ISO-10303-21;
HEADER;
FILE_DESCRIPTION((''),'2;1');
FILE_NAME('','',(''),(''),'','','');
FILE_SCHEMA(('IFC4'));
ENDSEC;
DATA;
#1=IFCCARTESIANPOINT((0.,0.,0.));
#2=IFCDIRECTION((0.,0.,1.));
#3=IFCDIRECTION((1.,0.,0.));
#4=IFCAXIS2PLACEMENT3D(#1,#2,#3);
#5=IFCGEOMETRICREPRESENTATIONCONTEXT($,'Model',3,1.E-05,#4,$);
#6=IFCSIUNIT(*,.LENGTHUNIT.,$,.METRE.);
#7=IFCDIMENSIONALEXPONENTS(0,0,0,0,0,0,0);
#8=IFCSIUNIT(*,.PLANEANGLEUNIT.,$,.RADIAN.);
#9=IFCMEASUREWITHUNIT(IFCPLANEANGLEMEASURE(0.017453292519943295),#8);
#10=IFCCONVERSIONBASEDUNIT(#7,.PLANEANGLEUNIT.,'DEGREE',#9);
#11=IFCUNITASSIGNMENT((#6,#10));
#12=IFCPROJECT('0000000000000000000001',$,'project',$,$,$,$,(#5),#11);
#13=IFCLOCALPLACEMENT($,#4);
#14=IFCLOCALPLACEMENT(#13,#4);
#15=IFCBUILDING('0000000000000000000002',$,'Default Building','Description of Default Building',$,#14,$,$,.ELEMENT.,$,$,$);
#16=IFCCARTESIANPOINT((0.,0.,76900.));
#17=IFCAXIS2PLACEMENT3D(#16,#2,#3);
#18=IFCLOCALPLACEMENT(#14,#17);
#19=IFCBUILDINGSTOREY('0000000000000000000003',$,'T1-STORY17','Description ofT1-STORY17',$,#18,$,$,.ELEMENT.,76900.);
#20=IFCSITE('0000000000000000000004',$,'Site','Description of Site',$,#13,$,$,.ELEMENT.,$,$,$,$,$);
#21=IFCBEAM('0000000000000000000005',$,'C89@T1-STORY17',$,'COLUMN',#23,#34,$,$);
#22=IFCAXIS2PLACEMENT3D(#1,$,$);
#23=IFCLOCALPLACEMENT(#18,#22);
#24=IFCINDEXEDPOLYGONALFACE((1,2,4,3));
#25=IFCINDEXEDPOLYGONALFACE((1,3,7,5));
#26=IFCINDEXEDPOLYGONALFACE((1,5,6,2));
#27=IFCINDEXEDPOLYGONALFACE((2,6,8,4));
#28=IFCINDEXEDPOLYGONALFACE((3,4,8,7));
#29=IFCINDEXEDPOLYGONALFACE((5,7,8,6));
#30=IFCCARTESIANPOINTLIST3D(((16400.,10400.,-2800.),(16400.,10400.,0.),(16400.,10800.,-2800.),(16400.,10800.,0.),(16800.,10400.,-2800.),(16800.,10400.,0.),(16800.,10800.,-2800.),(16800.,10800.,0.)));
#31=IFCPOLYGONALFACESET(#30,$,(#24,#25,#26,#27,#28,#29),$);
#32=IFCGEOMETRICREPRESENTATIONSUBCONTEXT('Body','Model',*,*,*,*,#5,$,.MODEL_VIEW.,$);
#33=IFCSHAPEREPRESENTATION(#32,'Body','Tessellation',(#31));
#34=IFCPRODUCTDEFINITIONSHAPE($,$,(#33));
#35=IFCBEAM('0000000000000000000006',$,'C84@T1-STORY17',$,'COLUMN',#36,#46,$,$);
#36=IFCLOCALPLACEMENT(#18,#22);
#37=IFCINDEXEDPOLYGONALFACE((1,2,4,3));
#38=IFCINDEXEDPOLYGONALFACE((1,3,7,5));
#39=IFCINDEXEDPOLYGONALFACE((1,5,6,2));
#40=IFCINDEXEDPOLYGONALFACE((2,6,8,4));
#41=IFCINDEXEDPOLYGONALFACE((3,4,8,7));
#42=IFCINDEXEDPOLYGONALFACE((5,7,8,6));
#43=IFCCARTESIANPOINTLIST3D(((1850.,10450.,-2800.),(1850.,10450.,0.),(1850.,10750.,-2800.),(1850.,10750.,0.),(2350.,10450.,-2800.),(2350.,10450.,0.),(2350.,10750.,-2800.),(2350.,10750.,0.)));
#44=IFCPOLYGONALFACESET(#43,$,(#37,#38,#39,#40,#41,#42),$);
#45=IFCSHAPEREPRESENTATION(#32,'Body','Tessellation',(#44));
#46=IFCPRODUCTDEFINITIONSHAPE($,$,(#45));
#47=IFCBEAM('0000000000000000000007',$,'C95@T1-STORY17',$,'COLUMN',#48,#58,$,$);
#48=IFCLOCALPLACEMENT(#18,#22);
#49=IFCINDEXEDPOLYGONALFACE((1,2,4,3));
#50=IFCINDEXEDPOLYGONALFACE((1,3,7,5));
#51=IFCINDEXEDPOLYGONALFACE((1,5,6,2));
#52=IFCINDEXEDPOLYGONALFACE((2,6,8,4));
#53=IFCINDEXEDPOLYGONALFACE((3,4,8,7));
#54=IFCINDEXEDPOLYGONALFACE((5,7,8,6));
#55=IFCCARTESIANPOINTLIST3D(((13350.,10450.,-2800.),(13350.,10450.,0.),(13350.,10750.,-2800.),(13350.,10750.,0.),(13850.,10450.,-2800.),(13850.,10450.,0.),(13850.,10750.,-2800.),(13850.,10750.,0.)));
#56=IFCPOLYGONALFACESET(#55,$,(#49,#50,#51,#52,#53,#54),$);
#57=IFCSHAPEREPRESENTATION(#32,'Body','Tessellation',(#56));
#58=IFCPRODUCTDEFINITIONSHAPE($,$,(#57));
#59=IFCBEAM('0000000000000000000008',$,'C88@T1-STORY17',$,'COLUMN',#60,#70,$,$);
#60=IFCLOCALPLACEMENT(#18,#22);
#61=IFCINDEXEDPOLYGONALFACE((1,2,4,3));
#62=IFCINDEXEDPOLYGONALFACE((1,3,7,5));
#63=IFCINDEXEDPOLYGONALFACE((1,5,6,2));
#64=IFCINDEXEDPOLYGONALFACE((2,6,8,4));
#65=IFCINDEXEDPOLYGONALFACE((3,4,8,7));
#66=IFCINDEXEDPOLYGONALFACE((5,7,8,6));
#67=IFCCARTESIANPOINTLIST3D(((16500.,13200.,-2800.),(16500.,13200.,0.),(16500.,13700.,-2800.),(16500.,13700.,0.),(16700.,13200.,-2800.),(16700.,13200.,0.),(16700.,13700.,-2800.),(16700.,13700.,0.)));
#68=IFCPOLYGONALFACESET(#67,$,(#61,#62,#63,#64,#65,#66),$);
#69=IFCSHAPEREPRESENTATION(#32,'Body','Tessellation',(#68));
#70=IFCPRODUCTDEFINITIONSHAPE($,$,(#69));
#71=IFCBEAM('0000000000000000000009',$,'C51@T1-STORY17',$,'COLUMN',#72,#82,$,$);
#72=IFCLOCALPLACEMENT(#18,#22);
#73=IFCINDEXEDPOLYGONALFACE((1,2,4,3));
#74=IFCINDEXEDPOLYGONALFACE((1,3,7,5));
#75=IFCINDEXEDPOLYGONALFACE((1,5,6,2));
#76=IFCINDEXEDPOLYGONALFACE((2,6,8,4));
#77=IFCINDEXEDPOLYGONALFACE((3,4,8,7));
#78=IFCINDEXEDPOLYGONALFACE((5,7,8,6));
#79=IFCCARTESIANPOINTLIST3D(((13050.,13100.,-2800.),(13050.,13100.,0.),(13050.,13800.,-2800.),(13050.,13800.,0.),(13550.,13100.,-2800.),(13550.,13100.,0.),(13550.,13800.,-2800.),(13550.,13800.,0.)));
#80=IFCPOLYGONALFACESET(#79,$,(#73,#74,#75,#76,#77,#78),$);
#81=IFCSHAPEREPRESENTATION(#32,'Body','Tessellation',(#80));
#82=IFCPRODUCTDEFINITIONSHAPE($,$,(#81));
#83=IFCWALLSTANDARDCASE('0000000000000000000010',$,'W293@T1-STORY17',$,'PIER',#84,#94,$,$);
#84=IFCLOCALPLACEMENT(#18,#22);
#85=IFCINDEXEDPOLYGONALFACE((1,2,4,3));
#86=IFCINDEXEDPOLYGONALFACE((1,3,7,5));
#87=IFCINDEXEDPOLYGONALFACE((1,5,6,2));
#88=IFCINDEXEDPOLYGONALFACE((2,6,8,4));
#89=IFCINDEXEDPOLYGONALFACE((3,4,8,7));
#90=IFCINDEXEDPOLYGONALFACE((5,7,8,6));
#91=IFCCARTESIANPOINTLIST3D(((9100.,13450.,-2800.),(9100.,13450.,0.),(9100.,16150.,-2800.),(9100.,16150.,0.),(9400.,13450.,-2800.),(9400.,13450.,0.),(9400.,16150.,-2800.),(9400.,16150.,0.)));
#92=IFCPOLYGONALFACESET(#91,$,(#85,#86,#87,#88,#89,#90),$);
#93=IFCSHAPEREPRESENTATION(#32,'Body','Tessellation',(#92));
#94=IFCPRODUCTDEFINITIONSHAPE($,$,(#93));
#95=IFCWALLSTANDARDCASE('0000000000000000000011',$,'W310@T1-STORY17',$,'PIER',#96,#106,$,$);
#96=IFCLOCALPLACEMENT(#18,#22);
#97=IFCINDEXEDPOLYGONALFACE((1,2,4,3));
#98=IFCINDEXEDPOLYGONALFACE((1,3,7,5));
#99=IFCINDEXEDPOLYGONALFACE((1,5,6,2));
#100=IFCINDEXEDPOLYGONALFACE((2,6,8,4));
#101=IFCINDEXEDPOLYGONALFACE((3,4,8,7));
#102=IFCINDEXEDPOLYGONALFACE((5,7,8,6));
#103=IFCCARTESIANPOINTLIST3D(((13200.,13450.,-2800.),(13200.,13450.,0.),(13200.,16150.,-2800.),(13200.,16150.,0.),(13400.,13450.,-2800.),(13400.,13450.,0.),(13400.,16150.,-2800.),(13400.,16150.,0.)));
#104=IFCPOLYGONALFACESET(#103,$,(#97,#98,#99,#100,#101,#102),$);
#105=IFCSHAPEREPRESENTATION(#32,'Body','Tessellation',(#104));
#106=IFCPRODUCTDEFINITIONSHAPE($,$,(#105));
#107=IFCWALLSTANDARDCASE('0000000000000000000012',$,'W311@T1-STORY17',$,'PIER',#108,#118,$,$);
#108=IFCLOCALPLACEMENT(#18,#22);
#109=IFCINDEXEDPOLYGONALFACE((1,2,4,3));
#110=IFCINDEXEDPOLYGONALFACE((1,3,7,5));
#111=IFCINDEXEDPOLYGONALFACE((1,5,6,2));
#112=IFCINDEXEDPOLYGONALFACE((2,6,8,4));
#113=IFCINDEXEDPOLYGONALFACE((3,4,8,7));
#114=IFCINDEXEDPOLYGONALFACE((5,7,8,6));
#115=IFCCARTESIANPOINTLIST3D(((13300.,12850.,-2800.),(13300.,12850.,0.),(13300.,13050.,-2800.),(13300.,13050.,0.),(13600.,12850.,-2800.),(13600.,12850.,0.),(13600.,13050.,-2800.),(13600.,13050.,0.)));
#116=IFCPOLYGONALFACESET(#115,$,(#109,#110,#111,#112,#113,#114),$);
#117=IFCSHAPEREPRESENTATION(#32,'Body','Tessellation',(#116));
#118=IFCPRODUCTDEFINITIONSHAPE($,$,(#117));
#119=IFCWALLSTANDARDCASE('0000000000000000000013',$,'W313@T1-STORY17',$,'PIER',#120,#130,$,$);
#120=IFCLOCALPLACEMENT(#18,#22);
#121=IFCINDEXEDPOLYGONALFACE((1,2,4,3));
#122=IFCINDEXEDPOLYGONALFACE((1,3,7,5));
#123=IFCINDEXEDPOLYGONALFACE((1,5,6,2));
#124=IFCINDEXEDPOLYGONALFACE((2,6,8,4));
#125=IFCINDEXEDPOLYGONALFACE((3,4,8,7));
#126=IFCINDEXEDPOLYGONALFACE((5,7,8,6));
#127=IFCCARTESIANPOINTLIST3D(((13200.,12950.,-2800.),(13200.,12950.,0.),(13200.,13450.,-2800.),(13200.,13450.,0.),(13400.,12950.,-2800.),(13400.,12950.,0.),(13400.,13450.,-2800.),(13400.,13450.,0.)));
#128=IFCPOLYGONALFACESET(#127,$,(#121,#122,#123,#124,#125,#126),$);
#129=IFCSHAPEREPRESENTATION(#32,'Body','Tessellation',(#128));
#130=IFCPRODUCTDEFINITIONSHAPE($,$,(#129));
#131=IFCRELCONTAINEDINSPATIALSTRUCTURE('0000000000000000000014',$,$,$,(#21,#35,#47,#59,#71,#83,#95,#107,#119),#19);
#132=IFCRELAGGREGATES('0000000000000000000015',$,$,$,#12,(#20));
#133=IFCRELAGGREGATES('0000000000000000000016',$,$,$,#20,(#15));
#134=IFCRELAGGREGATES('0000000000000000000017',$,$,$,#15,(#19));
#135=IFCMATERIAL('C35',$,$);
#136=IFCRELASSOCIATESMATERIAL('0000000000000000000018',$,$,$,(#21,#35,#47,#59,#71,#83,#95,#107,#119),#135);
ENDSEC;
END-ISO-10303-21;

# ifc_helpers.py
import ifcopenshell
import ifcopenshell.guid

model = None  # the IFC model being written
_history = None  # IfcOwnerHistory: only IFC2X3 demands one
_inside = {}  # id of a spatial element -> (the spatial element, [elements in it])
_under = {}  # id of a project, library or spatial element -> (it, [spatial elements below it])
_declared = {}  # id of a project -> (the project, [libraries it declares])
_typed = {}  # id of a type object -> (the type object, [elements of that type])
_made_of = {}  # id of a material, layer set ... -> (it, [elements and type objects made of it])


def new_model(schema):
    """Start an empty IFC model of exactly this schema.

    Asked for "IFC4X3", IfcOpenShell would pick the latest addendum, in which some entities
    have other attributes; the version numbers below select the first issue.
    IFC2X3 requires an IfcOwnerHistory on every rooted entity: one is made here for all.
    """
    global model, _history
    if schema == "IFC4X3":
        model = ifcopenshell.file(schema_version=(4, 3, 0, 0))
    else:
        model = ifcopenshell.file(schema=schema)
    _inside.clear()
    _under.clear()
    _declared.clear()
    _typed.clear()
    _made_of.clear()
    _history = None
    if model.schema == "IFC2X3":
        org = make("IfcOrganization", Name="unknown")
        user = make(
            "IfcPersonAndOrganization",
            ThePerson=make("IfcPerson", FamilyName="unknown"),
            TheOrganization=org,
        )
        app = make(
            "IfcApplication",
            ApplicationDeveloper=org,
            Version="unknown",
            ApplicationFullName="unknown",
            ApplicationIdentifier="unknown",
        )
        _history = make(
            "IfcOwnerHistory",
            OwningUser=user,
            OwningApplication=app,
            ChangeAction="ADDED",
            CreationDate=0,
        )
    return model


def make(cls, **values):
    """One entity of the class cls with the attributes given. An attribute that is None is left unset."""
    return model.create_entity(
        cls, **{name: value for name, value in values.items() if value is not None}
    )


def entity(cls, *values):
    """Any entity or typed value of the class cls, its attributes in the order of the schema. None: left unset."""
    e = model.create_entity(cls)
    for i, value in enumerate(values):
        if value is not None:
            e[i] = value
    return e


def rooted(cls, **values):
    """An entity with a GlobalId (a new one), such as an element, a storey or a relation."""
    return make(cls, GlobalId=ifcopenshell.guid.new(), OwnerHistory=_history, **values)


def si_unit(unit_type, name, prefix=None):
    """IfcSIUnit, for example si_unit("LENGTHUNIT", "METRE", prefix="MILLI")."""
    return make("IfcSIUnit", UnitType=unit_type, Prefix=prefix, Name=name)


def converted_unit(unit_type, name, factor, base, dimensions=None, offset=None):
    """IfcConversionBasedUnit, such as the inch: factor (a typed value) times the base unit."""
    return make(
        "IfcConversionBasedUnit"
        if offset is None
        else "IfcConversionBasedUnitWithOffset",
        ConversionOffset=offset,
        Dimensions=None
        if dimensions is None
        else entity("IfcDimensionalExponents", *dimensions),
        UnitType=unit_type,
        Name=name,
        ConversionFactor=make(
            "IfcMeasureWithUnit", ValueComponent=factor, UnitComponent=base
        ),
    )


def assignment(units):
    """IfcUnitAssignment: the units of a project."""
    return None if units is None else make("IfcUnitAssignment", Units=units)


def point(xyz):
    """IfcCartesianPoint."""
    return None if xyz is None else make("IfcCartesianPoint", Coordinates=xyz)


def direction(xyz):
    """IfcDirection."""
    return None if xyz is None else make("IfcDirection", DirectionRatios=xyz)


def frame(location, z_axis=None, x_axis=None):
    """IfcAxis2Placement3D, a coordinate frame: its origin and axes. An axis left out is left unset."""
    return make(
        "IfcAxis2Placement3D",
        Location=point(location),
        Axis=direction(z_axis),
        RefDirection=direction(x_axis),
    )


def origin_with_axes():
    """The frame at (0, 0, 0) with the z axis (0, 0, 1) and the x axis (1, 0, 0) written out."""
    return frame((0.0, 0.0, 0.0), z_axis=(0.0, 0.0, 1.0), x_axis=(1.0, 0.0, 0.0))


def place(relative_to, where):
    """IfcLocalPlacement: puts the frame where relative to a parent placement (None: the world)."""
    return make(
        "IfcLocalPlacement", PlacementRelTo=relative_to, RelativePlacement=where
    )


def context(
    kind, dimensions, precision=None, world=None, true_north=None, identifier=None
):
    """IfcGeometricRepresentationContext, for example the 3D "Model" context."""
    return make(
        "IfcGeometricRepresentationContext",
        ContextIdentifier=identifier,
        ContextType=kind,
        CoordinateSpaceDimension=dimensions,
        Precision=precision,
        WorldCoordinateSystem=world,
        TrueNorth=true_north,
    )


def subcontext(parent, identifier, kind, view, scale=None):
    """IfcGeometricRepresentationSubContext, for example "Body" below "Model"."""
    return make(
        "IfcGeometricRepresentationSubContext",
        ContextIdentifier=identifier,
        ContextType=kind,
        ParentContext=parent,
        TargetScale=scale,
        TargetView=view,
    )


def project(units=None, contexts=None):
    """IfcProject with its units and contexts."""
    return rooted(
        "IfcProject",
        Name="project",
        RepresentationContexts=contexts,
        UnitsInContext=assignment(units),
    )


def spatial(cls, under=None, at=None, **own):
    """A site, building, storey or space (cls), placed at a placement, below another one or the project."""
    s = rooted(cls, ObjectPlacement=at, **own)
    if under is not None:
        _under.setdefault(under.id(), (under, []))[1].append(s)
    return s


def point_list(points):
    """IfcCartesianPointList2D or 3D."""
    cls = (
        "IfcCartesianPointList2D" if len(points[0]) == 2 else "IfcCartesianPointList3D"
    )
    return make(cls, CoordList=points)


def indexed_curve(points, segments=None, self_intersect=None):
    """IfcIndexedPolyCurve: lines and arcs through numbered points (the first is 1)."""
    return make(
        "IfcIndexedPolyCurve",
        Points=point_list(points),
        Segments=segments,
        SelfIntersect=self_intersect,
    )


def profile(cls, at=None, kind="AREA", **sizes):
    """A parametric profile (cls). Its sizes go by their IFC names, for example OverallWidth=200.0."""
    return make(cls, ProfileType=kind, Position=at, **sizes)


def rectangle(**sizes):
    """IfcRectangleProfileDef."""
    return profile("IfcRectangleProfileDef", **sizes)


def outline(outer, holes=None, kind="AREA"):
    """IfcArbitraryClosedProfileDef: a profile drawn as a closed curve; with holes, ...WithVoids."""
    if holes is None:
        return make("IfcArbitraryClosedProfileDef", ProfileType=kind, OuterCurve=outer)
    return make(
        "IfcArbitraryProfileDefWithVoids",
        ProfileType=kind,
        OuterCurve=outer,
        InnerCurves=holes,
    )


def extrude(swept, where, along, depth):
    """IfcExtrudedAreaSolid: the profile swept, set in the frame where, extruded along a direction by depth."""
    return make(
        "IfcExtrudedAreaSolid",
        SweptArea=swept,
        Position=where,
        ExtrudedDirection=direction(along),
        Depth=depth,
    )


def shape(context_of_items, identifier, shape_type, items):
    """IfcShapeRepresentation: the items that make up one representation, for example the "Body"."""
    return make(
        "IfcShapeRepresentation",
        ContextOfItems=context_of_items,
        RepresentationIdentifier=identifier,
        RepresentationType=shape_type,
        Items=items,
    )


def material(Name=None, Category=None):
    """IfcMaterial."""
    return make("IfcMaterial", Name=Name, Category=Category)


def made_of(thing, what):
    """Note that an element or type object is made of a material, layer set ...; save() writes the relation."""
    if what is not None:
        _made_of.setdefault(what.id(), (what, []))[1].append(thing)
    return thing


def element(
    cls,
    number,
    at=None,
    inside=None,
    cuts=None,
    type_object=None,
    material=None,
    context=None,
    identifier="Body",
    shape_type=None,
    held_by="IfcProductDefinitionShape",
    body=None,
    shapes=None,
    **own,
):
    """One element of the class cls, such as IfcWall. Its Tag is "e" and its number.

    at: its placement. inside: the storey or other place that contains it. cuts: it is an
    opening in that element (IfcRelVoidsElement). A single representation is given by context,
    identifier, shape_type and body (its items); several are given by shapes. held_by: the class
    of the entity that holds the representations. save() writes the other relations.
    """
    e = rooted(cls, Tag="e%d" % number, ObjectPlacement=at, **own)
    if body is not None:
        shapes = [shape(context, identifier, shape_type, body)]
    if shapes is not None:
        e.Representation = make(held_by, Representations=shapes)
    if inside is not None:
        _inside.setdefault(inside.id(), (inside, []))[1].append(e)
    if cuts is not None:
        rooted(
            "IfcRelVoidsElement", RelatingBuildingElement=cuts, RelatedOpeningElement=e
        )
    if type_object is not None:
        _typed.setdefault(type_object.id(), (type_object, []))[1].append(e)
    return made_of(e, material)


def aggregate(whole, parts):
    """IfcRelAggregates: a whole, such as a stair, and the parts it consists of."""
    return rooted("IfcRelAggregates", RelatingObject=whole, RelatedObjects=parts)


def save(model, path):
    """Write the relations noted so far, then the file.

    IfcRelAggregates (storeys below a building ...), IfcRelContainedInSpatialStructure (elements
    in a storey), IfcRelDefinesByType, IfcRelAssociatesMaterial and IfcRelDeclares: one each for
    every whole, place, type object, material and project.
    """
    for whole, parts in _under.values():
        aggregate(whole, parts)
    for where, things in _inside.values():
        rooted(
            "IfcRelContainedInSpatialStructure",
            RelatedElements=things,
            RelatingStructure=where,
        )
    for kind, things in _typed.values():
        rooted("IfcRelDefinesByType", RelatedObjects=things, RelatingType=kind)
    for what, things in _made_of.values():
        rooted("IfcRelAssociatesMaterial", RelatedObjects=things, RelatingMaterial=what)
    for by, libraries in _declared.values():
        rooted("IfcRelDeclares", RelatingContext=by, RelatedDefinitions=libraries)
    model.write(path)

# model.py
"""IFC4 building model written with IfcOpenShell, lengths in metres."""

from ifc_helpers import new_model, entity, si_unit, converted_unit, frame, origin_with_axes, place, context, subcontext, project, spatial, indexed_curve, rectangle, outline, extrude, material, element, save


model = new_model("IFC4")

# Units and contexts
model_context = context("Model", 3, precision=1e-05, world=origin_with_axes())
body_context = subcontext(model_context, "Body", "Model", "MODEL_VIEW")
ifc_project = project(units=[si_unit("LENGTHUNIT", "METRE"), converted_unit("PLANEANGLEUNIT", "DEGREE", entity("IfcPlaneAngleMeasure", 0.017453292519943295), si_unit("PLANEANGLEUNIT", "RADIAN"), dimensions=[0, 0, 0, 0, 0, 0, 0])], contexts=[model_context])

# Site, building, storey
site_placement = place(None, origin_with_axes())
site = spatial("IfcSite", under=ifc_project, at=site_placement, Name="Site", Description="Description of Site", CompositionType="ELEMENT")
building_placement = place(site_placement, origin_with_axes())
building = spatial("IfcBuilding", under=site, at=building_placement, Name="Default Building", Description="Description of Default Building", CompositionType="ELEMENT")
storey_placement = place(building_placement, frame((0.0, 0.0, 76900.0), z_axis=(0.0, 0.0, 1.0), x_axis=(1.0, 0.0, 0.0)))
storey = spatial("IfcBuildingStorey", under=building, at=storey_placement, Name="T1-STORY17", Description="Description ofT1-STORY17", CompositionType="ELEMENT", Elevation=76900.0)

# Beams
ifc_material_1 = material(Name="C35")
for number, where, z_axis, x_axis, name in (
    (1, (16600.0, 10600.0, -2800.0), (0.0, 0.0, 1.0), (-1.0, 0.0, 0.0), "C89@T1-STORY17"),
):
    element("IfcBeam", number, at=place(storey_placement, frame(where, z_axis=z_axis, x_axis=x_axis)), inside=storey, material=ifc_material_1, Name=name, ObjectType="COLUMN", context=body_context, shape_type="SweptSolid", body=[
        extrude(rectangle(XDim=400.0, YDim=400.0), origin_with_axes(), (0.0, 0.0, 1.0), 2800.0),
    ])
for number, where, z_axis, x_axis, name in (
    (2, (2100.0, 10600.0, -2800.0), (0.0, 0.0, 1.0), (0.0, -1.0, 0.0), "C84@T1-STORY17"),
    (3, (13600.0, 10600.0, -2800.0), (0.0, 0.0, 1.0), (0.0, -1.0, 0.0), "C95@T1-STORY17"),
):
    element("IfcBeam", number, at=place(storey_placement, frame(where, z_axis=z_axis, x_axis=x_axis)), inside=storey, material=ifc_material_1, Name=name, ObjectType="COLUMN", context=body_context, shape_type="SweptSolid", body=[
        extrude(rectangle(XDim=300.0, YDim=500.0), origin_with_axes(), (0.0, 0.0, 1.0), 2800.0),
    ])
beam_1_placement = place(storey_placement, frame((16600.0, 13450.0, -2800.0), z_axis=(0.0, 0.0, 1.0), x_axis=(-1.0, 0.0, 0.0)))
element("IfcBeam", 4, at=beam_1_placement, inside=storey, material=ifc_material_1, Name="C88@T1-STORY17", ObjectType="COLUMN", context=body_context, shape_type="SweptSolid", body=[
    extrude(rectangle(XDim=200.0, YDim=500.0), origin_with_axes(), (0.0, 0.0, 1.0), 2800.0),
])
beam_2_placement = place(storey_placement, frame((13300.0, 13450.0, -2800.0), z_axis=(0.0, 0.0, 1.0), x_axis=(-1.0, 0.0, 0.0)))
element("IfcBeam", 5, at=beam_2_placement, inside=storey, material=ifc_material_1, Name="C51@T1-STORY17", ObjectType="COLUMN", context=body_context, shape_type="SweptSolid", body=[
    extrude(rectangle(XDim=500.0, YDim=700.0), origin_with_axes(), (0.0, 0.0, 1.0), 2800.0),
])

# Walls
wall_1_placement = place(storey_placement, frame((9250.0, 13450.0, -2800.0), z_axis=(0.0, 0.0, 1.0), x_axis=(0.0, 1.0, 0.0)))
element("IfcWallStandardCase", 6, at=wall_1_placement, inside=storey, material=ifc_material_1, Name="W293@T1-STORY17", ObjectType="PIER", context=body_context, shape_type="SweptSolid", body=[
    extrude(outline(indexed_curve([(0.0, -150.0), (0.0, 150.0), (2700.0, 150.0), (2700.0, -150.0), (0.0, -150.0)], self_intersect=False)), origin_with_axes(), (0.0, 0.0, 1.0), 2800.0),
])
wall_2_placement = place(storey_placement, frame((13300.0, 13450.0, -2800.0), z_axis=(0.0, 0.0, 1.0), x_axis=(0.0, 1.0, 0.0)))
element("IfcWallStandardCase", 7, at=wall_2_placement, inside=storey, material=ifc_material_1, Name="W310@T1-STORY17", ObjectType="PIER", context=body_context, shape_type="SweptSolid", body=[
    extrude(outline(indexed_curve([(0.0, -100.0), (0.0, 100.0), (2700.0, 100.0), (2700.0, -100.0), (0.0, -100.0)], self_intersect=False)), origin_with_axes(), (0.0, 0.0, 1.0), 2800.0),
])
wall_3_placement = place(storey_placement, frame((13300.0, 12950.0, -2800.0), z_axis=(0.0, 0.0, 1.0), x_axis=(1.0, 0.0, 0.0)))
element("IfcWallStandardCase", 8, at=wall_3_placement, inside=storey, material=ifc_material_1, Name="W311@T1-STORY17", ObjectType="PIER", context=body_context, shape_type="SweptSolid", body=[
    extrude(outline(indexed_curve([(0.0, -100.0), (0.0, 100.0), (300.0, 100.0), (300.0, -100.0), (0.0, -100.0)], self_intersect=False)), origin_with_axes(), (0.0, 0.0, 1.0), 2800.0),
])
wall_4_placement = place(storey_placement, frame((13300.0, 12950.0, -2800.0), z_axis=(0.0, 0.0, 1.0), x_axis=(0.0, 1.0, 0.0)))
element("IfcWallStandardCase", 9, at=wall_4_placement, inside=storey, material=ifc_material_1, Name="W313@T1-STORY17", ObjectType="PIER", context=body_context, shape_type="SweptSolid", body=[
    extrude(outline(indexed_curve([(0.0, -100.0), (0.0, 100.0), (500.0, 100.0), (500.0, -100.0), (0.0, -100.0)], self_intersect=False)), origin_with_axes(), (0.0, 0.0, 1.0), 2800.0),
])

save(model, "model.ifc")
